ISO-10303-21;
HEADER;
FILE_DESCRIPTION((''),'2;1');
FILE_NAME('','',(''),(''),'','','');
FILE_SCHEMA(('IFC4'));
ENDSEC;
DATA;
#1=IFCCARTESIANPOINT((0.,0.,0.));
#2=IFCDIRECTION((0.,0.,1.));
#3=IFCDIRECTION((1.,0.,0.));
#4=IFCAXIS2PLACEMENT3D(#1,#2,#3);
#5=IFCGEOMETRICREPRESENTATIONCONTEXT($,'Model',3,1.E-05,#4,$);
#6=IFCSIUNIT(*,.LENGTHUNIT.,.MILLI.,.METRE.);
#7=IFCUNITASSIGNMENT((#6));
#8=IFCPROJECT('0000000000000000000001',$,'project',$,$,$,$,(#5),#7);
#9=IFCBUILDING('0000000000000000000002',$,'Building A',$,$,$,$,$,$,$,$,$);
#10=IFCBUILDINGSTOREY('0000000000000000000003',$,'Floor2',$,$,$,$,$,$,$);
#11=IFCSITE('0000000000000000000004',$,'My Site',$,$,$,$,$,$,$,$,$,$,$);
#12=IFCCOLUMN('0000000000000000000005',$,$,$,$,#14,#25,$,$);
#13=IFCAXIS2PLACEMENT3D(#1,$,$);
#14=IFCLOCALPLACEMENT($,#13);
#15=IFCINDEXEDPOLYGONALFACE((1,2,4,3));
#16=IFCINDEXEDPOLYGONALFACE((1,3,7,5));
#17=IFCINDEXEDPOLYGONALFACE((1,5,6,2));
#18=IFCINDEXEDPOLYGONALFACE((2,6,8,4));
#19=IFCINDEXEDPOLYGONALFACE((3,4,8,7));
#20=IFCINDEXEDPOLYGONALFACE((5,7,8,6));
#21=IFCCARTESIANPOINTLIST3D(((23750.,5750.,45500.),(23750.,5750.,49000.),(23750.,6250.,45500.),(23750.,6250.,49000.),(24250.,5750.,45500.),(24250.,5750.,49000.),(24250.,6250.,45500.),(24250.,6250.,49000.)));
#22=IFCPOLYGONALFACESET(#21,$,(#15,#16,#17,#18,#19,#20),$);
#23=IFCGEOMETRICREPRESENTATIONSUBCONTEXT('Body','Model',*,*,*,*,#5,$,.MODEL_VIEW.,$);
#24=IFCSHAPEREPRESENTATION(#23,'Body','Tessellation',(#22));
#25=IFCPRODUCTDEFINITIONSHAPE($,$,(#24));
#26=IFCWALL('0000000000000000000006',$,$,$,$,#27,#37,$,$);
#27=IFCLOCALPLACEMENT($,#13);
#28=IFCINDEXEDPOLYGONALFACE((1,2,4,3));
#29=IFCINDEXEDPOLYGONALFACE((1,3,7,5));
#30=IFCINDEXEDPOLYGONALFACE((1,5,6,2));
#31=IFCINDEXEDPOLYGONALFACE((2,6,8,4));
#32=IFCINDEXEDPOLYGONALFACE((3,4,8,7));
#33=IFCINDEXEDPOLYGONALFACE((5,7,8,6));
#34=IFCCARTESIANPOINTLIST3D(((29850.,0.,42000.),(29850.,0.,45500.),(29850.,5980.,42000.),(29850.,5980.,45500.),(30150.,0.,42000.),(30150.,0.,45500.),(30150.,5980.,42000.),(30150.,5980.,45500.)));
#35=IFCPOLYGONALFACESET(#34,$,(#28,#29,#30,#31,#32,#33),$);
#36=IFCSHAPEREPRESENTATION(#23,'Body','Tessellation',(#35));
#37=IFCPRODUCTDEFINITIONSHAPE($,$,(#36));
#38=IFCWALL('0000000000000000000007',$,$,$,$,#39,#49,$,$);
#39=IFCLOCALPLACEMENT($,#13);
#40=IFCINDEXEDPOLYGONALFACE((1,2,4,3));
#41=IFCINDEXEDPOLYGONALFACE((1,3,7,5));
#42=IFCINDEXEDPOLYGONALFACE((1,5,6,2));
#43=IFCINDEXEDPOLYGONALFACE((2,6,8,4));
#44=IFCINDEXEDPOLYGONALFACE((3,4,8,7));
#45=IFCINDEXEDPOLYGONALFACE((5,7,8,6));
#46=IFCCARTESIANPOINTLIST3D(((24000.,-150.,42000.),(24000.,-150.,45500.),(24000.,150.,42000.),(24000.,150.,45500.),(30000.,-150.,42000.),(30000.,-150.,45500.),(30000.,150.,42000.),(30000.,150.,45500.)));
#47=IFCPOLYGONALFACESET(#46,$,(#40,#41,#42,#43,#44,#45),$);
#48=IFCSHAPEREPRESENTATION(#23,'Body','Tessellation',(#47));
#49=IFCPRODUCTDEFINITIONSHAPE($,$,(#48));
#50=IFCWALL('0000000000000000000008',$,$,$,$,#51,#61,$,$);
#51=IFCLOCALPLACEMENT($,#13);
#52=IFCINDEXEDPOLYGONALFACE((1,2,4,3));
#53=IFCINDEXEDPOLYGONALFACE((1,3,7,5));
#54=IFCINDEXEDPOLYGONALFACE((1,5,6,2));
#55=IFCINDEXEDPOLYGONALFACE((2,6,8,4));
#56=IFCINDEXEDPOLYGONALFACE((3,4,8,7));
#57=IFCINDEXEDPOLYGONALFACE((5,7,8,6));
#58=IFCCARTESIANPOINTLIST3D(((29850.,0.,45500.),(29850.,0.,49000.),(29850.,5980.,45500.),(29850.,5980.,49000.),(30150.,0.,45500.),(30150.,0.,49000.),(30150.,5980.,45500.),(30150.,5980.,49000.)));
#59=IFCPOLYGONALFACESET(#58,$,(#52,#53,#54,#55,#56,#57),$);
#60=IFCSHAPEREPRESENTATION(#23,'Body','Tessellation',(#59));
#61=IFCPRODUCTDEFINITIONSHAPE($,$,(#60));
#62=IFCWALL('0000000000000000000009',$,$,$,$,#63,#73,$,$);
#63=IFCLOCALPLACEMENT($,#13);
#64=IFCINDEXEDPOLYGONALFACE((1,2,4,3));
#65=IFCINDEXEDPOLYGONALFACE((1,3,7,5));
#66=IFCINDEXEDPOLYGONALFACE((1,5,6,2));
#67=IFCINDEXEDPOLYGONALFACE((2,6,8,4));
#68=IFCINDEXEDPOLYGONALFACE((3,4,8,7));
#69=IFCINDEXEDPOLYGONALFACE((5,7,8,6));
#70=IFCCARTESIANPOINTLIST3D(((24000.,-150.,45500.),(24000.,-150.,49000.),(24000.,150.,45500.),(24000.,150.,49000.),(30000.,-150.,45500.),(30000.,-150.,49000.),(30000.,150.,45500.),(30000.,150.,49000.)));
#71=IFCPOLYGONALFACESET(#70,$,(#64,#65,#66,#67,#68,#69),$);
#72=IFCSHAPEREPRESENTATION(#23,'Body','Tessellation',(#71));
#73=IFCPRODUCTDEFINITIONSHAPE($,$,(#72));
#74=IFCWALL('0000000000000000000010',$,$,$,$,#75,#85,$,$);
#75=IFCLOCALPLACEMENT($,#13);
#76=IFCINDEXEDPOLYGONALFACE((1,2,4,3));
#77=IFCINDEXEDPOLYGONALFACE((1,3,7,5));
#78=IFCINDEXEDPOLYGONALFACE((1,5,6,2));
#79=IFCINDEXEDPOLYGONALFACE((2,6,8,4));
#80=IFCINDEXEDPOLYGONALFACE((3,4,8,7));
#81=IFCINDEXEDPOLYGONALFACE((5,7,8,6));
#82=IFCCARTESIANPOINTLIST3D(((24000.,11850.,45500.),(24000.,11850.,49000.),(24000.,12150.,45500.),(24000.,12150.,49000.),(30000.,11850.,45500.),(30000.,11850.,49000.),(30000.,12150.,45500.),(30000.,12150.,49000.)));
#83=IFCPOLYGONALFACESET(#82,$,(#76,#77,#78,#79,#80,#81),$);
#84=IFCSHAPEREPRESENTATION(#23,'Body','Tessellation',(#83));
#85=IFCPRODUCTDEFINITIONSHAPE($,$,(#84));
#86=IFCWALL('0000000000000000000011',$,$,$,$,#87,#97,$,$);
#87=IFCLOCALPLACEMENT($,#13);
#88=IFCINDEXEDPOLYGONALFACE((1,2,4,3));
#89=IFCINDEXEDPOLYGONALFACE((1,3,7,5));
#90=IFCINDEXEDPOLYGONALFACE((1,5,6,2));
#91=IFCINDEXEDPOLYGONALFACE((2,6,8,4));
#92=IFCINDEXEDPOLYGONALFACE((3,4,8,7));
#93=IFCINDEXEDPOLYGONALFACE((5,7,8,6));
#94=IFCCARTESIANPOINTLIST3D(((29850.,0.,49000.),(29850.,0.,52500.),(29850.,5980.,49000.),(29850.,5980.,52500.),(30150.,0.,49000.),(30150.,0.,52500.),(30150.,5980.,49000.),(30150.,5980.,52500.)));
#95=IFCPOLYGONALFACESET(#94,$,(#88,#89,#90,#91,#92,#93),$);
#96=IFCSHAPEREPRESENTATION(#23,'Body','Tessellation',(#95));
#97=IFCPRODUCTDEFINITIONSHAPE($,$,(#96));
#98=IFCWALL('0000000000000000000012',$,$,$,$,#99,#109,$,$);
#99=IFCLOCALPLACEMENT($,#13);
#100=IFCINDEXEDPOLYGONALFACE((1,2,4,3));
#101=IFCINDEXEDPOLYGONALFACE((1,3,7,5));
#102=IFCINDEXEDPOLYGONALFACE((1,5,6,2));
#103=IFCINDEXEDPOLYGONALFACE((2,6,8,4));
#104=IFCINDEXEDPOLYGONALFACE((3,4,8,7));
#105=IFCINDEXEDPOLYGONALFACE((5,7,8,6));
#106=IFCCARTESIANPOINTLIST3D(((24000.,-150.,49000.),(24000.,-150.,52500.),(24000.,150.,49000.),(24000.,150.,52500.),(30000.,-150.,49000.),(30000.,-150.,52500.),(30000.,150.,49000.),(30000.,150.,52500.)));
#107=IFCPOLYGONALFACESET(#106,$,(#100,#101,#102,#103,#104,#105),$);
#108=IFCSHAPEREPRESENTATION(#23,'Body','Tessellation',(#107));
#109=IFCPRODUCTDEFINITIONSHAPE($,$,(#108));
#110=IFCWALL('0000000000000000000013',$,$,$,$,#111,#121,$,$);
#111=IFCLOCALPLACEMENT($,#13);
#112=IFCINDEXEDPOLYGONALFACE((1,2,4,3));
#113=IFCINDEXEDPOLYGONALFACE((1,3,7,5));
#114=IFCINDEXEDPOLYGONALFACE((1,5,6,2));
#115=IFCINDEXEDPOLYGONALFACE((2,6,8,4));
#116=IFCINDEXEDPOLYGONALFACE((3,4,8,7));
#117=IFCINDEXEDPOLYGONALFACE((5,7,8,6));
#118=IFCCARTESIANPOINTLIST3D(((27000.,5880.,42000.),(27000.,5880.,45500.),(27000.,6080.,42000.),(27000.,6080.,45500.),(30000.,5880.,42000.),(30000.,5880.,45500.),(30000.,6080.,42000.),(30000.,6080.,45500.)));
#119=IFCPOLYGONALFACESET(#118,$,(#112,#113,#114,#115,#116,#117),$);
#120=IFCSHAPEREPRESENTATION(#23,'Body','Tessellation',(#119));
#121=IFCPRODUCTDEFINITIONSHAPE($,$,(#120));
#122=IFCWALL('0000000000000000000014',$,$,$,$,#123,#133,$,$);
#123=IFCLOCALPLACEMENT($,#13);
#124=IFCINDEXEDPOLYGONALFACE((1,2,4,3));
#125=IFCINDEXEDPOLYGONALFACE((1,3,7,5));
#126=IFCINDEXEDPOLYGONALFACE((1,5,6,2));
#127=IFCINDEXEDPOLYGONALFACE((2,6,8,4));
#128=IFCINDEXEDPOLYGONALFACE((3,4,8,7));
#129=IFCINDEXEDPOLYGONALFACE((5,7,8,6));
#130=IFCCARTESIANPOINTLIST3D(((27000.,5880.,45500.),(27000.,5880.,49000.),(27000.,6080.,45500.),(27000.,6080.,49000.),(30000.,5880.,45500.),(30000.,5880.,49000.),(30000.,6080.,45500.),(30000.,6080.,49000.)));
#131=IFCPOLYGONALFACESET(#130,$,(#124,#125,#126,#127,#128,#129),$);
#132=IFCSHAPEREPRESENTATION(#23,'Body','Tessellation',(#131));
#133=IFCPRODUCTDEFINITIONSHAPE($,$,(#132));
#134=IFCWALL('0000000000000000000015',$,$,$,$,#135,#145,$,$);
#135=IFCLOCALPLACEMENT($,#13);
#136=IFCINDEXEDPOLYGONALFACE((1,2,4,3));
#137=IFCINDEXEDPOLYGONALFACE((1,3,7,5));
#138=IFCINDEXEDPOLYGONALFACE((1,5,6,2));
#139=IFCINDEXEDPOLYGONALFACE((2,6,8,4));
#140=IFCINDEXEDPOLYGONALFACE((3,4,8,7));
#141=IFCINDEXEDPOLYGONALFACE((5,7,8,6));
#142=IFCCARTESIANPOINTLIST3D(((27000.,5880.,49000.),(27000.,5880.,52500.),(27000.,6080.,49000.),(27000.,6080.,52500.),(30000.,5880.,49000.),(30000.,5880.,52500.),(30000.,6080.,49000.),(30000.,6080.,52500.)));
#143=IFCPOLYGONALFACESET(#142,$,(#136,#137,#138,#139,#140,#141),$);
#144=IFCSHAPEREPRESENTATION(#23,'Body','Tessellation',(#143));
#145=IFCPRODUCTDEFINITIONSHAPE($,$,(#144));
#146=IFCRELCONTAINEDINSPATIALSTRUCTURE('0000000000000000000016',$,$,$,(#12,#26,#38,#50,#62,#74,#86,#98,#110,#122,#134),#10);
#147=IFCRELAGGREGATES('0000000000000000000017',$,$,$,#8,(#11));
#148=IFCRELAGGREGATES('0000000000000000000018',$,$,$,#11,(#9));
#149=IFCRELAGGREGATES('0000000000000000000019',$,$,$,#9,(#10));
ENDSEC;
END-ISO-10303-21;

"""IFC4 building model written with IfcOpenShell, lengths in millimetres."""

from ifc_helpers import new_model, si_unit, frame, origin_with_axes, place, context, subcontext, project, spatial, line, indexed_curve, outline, extrude, element, save


model = new_model("IFC4")

# Units and contexts
model_context = context("Model", 3, precision=1e-05, world=origin_with_axes())
body_context = subcontext(model_context, "Body", "Model", "MODEL_VIEW")
ifc_project = project(units=[si_unit("LENGTHUNIT", "METRE", prefix="MILLI")], contexts=[model_context])

# Site, building, storey
site = spatial("IfcSite", under=ifc_project, Name="My Site")
building = spatial("IfcBuilding", under=site, Name="Building A")
storey = spatial("IfcBuildingStorey", under=building, Name="Floor2")

# Column
column_placement = place(None, frame((24000.0, 6000.0, 45500.0), z_axis=(0.0, 0.0, 1.0), x_axis=(1.0, 0.0, 0.0)))
element("IfcColumn", 1, at=column_placement, inside=storey, context=body_context, shape_type="SweptSolid", body=[
    extrude(outline(indexed_curve([(-250.0, -250.0), (250.0, -250.0), (250.0, 250.0), (-250.0, 250.0)], segments=[line(1, 2, 3, 4, 1)])), origin_with_axes(), (0.0, 0.0, 1.0), 3500.0),
])

# Walls
wall_1_placement = place(None, frame((29850.0, 5980.0, 42000.0), z_axis=(0.0, 0.0, 1.0), x_axis=(0.0, -1.0, 0.0)))
element("IfcWall", 2, at=wall_1_placement, inside=storey, context=body_context, shape_type="SweptSolid", body=[
    extrude(outline(indexed_curve([(0.0, 0.0), (0.0, 300.0), (5980.0, 300.0), (5980.0, 0.0), (0.0, 0.0)], self_intersect=False)), origin_with_axes(), (0.0, 0.0, 1.0), 3500.0),
])
wall_2_placement = place(None, frame((30000.0, 150.0, 42000.0), z_axis=(0.0, 0.0, 1.0), x_axis=(-1.0, 0.0, 0.0)))
element("IfcWall", 3, at=wall_2_placement, inside=storey, context=body_context, shape_type="SweptSolid", body=[
    extrude(outline(indexed_curve([(0.0, 0.0), (0.0, 300.0), (6000.0, 300.0), (6000.0, 0.0), (0.0, 0.0)], self_intersect=False)), origin_with_axes(), (0.0, 0.0, 1.0), 3500.0),
])
wall_3_placement = place(None, frame((29850.0, 5980.0, 45500.0), z_axis=(0.0, 0.0, 1.0), x_axis=(0.0, -1.0, 0.0)))
element("IfcWall", 4, at=wall_3_placement, inside=storey, context=body_context, shape_type="SweptSolid", body=[
    extrude(outline(indexed_curve([(0.0, 0.0), (0.0, 300.0), (5980.0, 300.0), (5980.0, 0.0), (0.0, 0.0)], self_intersect=False)), origin_with_axes(), (0.0, 0.0, 1.0), 3500.0),
])
for number, where, z_axis, x_axis in (
    (5, (30000.0, 150.0, 45500.0), (0.0, 0.0, 1.0), (-1.0, 0.0, 0.0)),
    (6, (24000.0, 11850.0, 45500.0), (0.0, 0.0, 1.0), (1.0, 0.0, 0.0)),
):
    element("IfcWall", number, at=place(None, frame(where, z_axis=z_axis, x_axis=x_axis)), inside=storey, context=body_context, shape_type="SweptSolid", body=[
        extrude(outline(indexed_curve([(0.0, 0.0), (0.0, 300.0), (6000.0, 300.0), (6000.0, 0.0), (0.0, 0.0)], self_intersect=False)), origin_with_axes(), (0.0, 0.0, 1.0), 3500.0),
    ])
wall_4_placement = place(None, frame((29850.0, 5980.0, 49000.0), z_axis=(0.0, 0.0, 1.0), x_axis=(0.0, -1.0, 0.0)))
element("IfcWall", 7, at=wall_4_placement, inside=storey, context=body_context, shape_type="SweptSolid", body=[
    extrude(outline(indexed_curve([(0.0, 0.0), (0.0, 300.0), (5980.0, 300.0), (5980.0, 0.0), (0.0, 0.0)], self_intersect=False)), origin_with_axes(), (0.0, 0.0, 1.0), 3500.0),
])
wall_5_placement = place(None, frame((30000.0, 150.0, 49000.0), z_axis=(0.0, 0.0, 1.0), x_axis=(-1.0, 0.0, 0.0)))
element("IfcWall", 8, at=wall_5_placement, inside=storey, context=body_context, shape_type="SweptSolid", body=[
    extrude(outline(indexed_curve([(0.0, 0.0), (0.0, 300.0), (6000.0, 300.0), (6000.0, 0.0), (0.0, 0.0)], self_intersect=False)), origin_with_axes(), (0.0, 0.0, 1.0), 3500.0),
])
for number, where, z_axis, x_axis in (
    (9, (27000.0, 5880.0, 42000.0), (0.0, 0.0, 1.0), (1.0, 0.0, 0.0)),
    (10, (27000.0, 5880.0, 45500.0), (0.0, 0.0, 1.0), (1.0, 0.0, 0.0)),
    (11, (27000.0, 5880.0, 49000.0), (0.0, 0.0, 1.0), (1.0, 0.0, 0.0)),
):
    element("IfcWall", number, at=place(None, frame(where, z_axis=z_axis, x_axis=x_axis)), inside=storey, context=body_context, shape_type="SweptSolid", body=[
        extrude(outline(indexed_curve([(0.0, 0.0), (0.0, 200.0), (3000.0, 200.0), (3000.0, 0.0), (0.0, 0.0)], self_intersect=False)), origin_with_axes(), (0.0, 0.0, 1.0), 3500.0),
    ])

save(model, "model.ifc")
